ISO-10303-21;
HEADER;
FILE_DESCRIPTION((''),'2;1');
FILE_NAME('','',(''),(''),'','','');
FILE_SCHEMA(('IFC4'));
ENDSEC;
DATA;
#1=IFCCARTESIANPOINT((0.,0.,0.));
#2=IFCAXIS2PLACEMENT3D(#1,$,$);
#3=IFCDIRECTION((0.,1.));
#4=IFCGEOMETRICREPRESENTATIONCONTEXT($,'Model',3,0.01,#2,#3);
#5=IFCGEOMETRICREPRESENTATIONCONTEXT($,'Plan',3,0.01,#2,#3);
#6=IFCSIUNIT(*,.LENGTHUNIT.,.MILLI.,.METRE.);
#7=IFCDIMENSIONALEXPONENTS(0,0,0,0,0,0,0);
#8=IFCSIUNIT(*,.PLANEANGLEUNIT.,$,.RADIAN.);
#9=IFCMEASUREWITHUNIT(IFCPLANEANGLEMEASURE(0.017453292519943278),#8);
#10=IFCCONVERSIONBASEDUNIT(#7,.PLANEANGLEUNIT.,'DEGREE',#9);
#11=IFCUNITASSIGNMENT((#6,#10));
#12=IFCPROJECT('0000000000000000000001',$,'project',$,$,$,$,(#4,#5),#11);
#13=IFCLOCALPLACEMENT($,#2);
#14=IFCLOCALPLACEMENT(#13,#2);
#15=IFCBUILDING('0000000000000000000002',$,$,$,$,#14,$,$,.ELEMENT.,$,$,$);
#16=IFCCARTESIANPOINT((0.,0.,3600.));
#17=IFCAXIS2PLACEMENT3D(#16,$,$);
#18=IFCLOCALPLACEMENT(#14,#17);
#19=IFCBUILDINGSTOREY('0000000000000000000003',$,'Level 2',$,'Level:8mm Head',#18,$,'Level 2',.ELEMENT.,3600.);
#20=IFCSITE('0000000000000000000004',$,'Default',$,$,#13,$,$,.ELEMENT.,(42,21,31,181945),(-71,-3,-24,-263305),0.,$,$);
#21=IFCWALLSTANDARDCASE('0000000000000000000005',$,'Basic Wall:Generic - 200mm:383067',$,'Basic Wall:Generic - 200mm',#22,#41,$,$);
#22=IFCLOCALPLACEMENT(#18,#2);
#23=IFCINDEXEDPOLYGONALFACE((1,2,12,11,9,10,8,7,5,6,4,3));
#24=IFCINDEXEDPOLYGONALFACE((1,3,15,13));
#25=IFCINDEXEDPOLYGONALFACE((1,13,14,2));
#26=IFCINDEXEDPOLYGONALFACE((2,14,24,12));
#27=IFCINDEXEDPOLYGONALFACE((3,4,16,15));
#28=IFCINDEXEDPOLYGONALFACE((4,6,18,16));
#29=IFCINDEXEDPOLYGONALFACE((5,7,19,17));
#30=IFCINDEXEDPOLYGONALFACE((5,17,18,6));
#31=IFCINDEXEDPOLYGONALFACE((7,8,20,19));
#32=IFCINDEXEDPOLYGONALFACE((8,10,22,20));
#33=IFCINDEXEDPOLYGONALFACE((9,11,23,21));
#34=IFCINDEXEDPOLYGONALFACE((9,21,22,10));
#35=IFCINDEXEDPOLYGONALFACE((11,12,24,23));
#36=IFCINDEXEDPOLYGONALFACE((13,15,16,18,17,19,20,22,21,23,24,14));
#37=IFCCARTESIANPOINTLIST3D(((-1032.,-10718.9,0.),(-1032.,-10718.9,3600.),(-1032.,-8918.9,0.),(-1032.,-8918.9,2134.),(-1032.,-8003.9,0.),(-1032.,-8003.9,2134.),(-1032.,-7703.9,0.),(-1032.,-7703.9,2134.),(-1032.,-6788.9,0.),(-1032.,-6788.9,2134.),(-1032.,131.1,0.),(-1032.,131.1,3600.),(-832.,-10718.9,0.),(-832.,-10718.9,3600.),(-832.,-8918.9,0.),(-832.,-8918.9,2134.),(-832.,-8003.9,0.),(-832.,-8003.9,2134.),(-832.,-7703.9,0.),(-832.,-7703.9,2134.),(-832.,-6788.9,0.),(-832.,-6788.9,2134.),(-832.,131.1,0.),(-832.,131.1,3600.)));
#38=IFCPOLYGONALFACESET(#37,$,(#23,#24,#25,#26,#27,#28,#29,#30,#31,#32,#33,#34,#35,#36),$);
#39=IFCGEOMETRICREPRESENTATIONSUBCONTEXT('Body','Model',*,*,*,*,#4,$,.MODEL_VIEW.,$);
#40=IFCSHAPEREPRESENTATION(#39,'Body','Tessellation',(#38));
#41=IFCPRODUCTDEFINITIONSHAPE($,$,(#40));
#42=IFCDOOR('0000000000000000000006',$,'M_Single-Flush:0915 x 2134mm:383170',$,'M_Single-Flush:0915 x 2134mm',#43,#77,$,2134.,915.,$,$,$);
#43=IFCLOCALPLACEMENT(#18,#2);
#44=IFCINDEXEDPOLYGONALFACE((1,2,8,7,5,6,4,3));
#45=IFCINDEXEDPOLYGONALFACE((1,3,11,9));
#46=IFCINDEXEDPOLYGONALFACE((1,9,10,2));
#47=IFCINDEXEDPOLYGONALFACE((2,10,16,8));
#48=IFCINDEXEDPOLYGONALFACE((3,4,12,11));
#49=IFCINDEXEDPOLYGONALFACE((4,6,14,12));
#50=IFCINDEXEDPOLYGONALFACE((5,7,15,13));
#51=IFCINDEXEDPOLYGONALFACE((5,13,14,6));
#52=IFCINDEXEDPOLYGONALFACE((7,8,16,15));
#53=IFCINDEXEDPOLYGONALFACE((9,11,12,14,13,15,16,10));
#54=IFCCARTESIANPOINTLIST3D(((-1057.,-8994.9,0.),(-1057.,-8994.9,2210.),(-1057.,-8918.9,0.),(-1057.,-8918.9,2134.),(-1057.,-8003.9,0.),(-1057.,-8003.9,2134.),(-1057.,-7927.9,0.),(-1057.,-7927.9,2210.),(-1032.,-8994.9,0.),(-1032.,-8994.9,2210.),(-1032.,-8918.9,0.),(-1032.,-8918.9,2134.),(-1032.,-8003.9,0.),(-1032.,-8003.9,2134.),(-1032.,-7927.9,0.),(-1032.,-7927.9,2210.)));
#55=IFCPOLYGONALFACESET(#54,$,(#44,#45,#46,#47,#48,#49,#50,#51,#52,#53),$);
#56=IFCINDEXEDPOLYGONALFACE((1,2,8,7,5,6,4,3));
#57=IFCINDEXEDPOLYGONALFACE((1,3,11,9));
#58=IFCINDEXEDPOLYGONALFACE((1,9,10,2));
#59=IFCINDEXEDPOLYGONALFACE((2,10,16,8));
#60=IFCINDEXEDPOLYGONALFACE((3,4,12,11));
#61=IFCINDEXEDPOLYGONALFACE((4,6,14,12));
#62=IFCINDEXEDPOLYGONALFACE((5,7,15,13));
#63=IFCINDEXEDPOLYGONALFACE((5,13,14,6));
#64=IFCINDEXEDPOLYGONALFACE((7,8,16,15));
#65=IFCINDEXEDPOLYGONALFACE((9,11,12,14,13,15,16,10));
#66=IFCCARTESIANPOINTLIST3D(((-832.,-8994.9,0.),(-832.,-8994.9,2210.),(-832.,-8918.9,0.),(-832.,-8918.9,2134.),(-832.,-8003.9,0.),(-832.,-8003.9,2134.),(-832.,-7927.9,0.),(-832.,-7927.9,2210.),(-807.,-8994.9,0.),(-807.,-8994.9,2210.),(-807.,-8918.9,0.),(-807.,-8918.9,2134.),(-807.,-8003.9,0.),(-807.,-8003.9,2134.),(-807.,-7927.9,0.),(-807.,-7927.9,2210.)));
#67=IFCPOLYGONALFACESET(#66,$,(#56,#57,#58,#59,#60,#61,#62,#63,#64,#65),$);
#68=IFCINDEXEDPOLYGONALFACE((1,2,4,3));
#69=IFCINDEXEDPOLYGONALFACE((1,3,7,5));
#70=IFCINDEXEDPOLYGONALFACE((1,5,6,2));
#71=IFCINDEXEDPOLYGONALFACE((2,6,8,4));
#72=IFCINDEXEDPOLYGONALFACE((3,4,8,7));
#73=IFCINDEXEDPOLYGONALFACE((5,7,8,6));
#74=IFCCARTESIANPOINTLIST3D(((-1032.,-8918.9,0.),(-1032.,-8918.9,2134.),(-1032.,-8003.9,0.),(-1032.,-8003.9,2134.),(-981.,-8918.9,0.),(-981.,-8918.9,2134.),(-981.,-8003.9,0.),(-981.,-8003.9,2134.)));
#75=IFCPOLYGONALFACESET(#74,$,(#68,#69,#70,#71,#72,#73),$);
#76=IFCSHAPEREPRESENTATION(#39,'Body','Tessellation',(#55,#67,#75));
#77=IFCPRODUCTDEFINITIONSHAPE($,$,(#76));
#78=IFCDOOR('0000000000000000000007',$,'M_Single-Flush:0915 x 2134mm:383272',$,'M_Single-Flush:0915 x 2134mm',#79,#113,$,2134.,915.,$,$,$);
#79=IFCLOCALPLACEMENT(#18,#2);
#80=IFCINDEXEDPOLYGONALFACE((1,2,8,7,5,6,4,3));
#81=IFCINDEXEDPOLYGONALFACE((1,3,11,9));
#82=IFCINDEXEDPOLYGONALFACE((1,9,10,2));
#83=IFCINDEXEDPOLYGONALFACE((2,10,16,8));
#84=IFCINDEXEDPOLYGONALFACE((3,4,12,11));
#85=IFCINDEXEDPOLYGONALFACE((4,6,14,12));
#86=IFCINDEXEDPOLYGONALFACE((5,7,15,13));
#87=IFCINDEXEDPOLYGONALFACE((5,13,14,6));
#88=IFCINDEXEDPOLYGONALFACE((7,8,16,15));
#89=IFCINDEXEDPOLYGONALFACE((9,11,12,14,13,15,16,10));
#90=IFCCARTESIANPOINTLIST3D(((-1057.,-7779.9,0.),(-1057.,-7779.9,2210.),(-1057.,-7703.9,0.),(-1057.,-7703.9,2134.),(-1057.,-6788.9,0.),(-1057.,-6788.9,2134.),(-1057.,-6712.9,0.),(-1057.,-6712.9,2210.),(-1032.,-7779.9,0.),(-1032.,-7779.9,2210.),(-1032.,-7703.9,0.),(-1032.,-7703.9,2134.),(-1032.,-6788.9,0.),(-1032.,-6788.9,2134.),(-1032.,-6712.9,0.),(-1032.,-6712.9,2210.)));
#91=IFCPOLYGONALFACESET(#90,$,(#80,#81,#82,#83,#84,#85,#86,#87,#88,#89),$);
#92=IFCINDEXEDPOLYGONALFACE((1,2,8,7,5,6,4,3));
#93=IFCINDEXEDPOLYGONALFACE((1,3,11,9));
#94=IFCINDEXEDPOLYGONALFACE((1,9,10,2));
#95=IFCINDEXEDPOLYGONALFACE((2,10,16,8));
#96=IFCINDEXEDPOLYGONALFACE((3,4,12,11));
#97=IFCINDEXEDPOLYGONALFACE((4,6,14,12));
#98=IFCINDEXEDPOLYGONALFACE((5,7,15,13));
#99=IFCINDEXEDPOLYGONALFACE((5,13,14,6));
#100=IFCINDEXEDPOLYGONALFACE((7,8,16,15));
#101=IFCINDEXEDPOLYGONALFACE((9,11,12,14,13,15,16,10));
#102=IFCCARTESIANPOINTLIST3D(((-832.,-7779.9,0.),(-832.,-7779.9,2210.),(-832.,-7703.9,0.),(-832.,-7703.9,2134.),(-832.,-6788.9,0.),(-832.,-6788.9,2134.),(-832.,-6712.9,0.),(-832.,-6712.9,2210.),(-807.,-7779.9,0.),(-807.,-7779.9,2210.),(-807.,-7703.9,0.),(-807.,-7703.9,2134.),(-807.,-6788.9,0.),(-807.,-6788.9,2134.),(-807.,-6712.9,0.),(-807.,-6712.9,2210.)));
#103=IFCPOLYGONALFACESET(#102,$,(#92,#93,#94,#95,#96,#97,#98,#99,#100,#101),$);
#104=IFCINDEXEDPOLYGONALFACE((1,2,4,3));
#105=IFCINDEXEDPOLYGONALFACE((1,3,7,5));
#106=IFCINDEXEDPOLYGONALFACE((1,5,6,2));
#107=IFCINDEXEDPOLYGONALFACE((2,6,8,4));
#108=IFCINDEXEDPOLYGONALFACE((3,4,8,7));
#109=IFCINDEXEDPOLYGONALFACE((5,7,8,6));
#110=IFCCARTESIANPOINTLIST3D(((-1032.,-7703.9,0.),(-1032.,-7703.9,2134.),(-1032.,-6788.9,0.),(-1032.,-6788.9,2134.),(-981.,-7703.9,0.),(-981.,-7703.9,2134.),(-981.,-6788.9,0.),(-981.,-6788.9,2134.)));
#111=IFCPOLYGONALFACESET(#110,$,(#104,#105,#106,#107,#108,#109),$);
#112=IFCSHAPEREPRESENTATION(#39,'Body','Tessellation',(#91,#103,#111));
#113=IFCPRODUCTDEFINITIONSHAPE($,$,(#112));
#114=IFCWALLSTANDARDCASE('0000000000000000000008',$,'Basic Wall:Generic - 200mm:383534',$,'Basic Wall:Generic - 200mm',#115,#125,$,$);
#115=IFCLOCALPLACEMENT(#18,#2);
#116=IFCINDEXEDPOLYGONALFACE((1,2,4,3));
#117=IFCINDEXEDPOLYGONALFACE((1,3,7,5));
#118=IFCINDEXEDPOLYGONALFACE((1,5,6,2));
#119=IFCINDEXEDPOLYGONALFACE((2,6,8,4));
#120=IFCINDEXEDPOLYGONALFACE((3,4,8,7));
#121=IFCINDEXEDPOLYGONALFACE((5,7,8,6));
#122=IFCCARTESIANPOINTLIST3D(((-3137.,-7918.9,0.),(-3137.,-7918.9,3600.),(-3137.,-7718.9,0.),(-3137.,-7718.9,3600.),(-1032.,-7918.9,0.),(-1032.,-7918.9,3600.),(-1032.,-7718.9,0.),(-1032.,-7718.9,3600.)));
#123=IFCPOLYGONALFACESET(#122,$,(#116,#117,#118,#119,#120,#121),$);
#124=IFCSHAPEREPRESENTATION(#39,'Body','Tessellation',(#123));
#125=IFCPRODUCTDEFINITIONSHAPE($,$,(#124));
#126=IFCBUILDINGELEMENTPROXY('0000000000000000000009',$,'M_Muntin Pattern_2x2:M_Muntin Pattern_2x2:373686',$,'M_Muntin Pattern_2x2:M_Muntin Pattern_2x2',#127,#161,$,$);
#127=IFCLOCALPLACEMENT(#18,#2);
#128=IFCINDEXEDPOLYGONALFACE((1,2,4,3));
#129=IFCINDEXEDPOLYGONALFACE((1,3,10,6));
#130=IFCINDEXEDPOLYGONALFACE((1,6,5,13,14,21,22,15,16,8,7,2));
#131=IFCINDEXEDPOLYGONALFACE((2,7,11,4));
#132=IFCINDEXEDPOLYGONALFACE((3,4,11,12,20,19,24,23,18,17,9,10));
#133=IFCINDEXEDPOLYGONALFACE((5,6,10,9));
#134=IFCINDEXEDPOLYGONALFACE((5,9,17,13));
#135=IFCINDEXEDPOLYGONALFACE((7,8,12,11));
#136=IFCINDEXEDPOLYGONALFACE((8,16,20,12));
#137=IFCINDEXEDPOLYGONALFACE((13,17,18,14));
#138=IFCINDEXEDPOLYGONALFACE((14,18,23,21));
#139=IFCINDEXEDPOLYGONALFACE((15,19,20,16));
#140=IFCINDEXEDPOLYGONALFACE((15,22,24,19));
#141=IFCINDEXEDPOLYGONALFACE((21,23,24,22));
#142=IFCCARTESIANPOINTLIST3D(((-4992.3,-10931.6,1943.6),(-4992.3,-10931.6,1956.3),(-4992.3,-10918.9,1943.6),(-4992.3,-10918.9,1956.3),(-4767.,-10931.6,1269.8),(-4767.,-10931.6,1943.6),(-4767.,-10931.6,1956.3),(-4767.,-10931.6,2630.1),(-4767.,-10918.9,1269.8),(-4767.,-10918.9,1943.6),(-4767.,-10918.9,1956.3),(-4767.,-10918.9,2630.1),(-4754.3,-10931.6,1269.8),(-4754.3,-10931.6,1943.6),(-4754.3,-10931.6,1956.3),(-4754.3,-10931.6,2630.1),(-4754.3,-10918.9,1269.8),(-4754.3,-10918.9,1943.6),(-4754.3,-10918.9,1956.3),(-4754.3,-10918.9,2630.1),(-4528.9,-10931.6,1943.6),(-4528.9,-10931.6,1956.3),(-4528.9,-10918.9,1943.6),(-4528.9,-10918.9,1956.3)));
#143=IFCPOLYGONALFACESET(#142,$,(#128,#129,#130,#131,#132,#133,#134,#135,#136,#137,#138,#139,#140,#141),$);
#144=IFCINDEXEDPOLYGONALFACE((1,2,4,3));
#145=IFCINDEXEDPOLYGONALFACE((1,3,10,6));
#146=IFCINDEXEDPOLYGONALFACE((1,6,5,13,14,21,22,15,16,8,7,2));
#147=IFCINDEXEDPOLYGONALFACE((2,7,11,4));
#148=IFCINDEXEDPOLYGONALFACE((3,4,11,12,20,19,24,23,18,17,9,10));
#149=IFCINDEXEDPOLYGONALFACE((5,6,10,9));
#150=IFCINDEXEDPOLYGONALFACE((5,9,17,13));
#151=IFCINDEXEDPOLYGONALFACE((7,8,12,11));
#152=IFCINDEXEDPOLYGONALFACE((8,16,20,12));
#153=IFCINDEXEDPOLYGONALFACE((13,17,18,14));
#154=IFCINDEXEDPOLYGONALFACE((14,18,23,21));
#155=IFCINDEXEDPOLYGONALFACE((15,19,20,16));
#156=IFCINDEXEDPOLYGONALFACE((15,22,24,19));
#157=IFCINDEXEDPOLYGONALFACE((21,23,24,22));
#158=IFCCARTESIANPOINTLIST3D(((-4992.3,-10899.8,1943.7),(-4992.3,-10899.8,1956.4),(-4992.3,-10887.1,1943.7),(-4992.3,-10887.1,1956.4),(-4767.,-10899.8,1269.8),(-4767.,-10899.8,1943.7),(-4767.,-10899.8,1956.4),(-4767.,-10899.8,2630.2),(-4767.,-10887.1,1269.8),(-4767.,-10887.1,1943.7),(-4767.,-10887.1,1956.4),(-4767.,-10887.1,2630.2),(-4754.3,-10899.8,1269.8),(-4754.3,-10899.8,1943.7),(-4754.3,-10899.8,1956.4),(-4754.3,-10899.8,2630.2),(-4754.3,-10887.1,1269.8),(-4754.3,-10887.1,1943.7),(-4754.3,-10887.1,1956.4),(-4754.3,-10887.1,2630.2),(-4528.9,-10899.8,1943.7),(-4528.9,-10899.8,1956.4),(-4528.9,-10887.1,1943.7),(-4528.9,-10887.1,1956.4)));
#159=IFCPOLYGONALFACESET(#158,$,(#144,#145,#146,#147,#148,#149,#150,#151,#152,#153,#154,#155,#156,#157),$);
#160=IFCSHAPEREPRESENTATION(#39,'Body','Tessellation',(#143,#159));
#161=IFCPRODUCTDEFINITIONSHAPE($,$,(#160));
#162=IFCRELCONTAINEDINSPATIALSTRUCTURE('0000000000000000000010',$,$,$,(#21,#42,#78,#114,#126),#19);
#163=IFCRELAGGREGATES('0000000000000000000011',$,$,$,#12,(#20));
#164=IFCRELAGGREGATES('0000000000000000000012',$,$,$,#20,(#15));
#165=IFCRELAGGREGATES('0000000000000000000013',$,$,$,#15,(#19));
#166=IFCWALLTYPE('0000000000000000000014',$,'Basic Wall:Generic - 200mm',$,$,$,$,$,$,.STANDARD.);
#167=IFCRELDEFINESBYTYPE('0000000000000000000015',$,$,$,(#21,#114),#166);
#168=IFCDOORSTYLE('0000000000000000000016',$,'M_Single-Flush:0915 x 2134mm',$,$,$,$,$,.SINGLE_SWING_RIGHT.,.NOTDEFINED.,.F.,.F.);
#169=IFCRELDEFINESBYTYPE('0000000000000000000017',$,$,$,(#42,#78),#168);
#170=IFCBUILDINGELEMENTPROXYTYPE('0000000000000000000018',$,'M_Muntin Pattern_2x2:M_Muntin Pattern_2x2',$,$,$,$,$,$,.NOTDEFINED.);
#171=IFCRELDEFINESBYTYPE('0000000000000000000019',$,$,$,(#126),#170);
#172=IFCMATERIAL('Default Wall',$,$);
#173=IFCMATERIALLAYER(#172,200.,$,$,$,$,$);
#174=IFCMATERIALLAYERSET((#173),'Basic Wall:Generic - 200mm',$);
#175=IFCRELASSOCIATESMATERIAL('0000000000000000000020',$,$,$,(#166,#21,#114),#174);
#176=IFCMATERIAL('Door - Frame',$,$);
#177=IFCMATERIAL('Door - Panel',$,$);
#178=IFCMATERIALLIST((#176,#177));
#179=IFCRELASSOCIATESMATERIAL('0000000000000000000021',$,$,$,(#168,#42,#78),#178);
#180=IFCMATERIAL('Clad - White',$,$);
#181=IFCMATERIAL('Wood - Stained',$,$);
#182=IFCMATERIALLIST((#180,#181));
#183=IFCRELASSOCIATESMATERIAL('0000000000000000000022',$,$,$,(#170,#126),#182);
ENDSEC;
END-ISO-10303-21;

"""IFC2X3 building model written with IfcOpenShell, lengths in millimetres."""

from ifc_helpers import new_model, entity, si_unit, converted_unit, direction, frame, frame_2d, origin, place, context, subcontext, project, spatial, polyline, rectangle, outline, extrude, source, transform, mapped, material, material_list, layer, layer_set, layer_usage, type_object, type_shapes, element, fill, save


model = new_model("IFC2X3")

# Units and contexts
model_context = context("Model", 3, precision=0.01, world=origin(), true_north=direction((0.0, 1.0)))
plan_context = context("Plan", 3, precision=0.01, world=origin(), true_north=direction((0.0, 1.0)))
body_context = subcontext(model_context, "Body", "Model", "MODEL_VIEW")
ifc_project = project(units=[si_unit("LENGTHUNIT", "METRE", prefix="MILLI"), converted_unit("PLANEANGLEUNIT", "DEGREE", entity("IfcPlaneAngleMeasure", 0.017453292519943278), si_unit("PLANEANGLEUNIT", "RADIAN"), dimensions=[0, 0, 0, 0, 0, 0, 0])], contexts=[model_context, plan_context])

# Site, building, storey
site_placement = place(None, origin())
site = spatial("IfcSite", under=ifc_project, at=site_placement, Name="Default", CompositionType="ELEMENT", RefLatitude=(42, 21, 31, 181945), RefLongitude=(-71, -3, -24, -263305), RefElevation=0.0)
building_placement = place(site_placement, origin())
building = spatial("IfcBuilding", under=site, at=building_placement, CompositionType="ELEMENT")
storey_placement = place(building_placement, frame((0.0, 0.0, 3600.0)))
storey = spatial("IfcBuildingStorey", under=building, at=storey_placement, Name="Level 2", ObjectType="Level:8mm Head", LongName="Level 2", CompositionType="ELEMENT", Elevation=3600.0)

# Shared definitions
ifc_material_1 = material(Name="Default Wall")
ifc_layer = layer(ifc_material_1, 200.0)
ifc_layer_set = layer_set([ifc_layer], Name="Basic Wall:Generic - 200mm")
wall_type = type_object("IfcWallType", Name="Basic Wall:Generic - 200mm", PredefinedType="STANDARD", material=ifc_layer_set)

# Wall, openings, doors
ifc_layer_usage_1 = layer_usage(ifc_layer_set, "AXIS2", "NEGATIVE", 100.0)
wall_1_placement = place(storey_placement, frame((-932.0, -10718.9, 0.0), z_axis=(0.0, 0.0, 1.0), x_axis=(0.0, 1.0, 0.0)))
wall_1 = element("IfcWallStandardCase", 1, at=wall_1_placement, inside=storey, type_object=wall_type, material=ifc_layer_usage_1, Name="Basic Wall:Generic - 200mm:383067", ObjectType="Basic Wall:Generic - 200mm", context=body_context, shape_type="SweptSolid", body=[
    extrude(rectangle(XDim=10850.0, YDim=200.0, at=frame_2d((5425.0, 0.0), x_axis=(1.0, 0.0))), origin(), (0.0, 0.0, 1.0), 3600.0),
])
opening_1_placement = place(wall_1_placement, frame((1800.0, -100.0, 0.0)))
opening_1 = element("IfcOpeningElement", 2, at=opening_1_placement, cuts=wall_1, ObjectType="Opening", context=body_context, shape_type="SweptSolid", body=[
    extrude(rectangle(XDim=915.0, YDim=2134.0, at=frame_2d((1067.0, 457.5), x_axis=(0.0, 1.0))), frame((0.0, 0.0, 0.0), z_axis=(0.0, 1.0, 0.0), x_axis=(0.0, 0.0, 1.0)), (0.0, 0.0, 1.0), 200.0),
])
opening_2_placement = place(wall_1_placement, frame((3015.0, -100.0, 0.0)))
opening_2 = element("IfcOpeningElement", 3, at=opening_2_placement, cuts=wall_1, ObjectType="Opening", context=body_context, shape_type="SweptSolid", body=[
    extrude(rectangle(XDim=915.0, YDim=2134.0, at=frame_2d((1067.0, 457.5), x_axis=(0.0, 1.0))), frame((0.0, 0.0, 0.0), z_axis=(0.0, 1.0, 0.0), x_axis=(0.0, 0.0, 1.0)), (0.0, 0.0, 1.0), 200.0),
])
ifc_material_2 = material(Name="Door - Frame")
ifc_material_3 = material(Name="Door - Panel")
ifc_material_list_1 = material_list([ifc_material_2, ifc_material_3])
door_style = type_object("IfcDoorStyle", Name="M_Single-Flush:0915 x 2134mm", ConstructionType="NOTDEFINED", OperationType="SINGLE_SWING_RIGHT", ParameterTakesPrecedence=False, Sizeable=False, material=ifc_material_list_1)
shared_shape_1 = source(origin(), body_context, "Body", "SweptSolid", [
    extrude(outline(polyline([(-533.5, -1124.0), (533.5, -1124.0), (533.5, 1086.0), (457.5, 1086.0), (457.5, -1048.0), (-457.5, -1048.0), (-457.5, 1086.0), (-533.5, 1086.0), (-533.5, -1124.0)])), frame((457.5, 200.0, 1086.0), z_axis=(0.0, 1.0, 0.0), x_axis=(1.0, 0.0, 0.0)), (0.0, 0.0, 1.0), 25.0),
    extrude(outline(polyline([(-1124.0, -533.5), (1086.0, -533.5), (1086.0, -457.5), (-1048.0, -457.5), (-1048.0, 457.5), (1086.0, 457.5), (1086.0, 533.5), (-1124.0, 533.5), (-1124.0, -533.5)])), frame((457.5, -25.0, 1086.0), z_axis=(0.0, 1.0, 0.0), x_axis=(0.0, 0.0, -1.0)), (0.0, 0.0, 1.0), 25.0),
    extrude(rectangle(XDim=51.0, YDim=915.0, at=frame_2d((0.0, 0.0), x_axis=(1.0, 0.0))), frame((457.5, 174.5, 0.0), z_axis=(0.0, 0.0, 1.0), x_axis=(0.0, 1.0, 0.0)), (0.0, 0.0, 1.0), 2134.0),
])
type_shapes(door_style, [shared_shape_1])
door_1_placement = place(opening_1_placement, origin())
door_1 = element("IfcDoor", 4, at=door_1_placement, inside=storey, type_object=door_style, material=ifc_material_list_1, Name="M_Single-Flush:0915 x 2134mm:383170", ObjectType="M_Single-Flush:0915 x 2134mm", OverallHeight=2134.0, OverallWidth=915.0, context=body_context, shape_type="MappedRepresentation", body=[
    mapped(shared_shape_1, transform((0.0, 0.0, 0.0), scale=1.0)),
])
fill(opening_1, door_1)
door_2_placement = place(opening_2_placement, origin())
door_2 = element("IfcDoor", 5, at=door_2_placement, inside=storey, type_object=door_style, material=ifc_material_list_1, Name="M_Single-Flush:0915 x 2134mm:383272", ObjectType="M_Single-Flush:0915 x 2134mm", OverallHeight=2134.0, OverallWidth=915.0, context=body_context, shape_type="MappedRepresentation", body=[
    mapped(shared_shape_1, transform((0.0, 0.0, 0.0), scale=1.0)),
])
fill(opening_2, door_2)

# Wall
ifc_layer_usage_2 = layer_usage(ifc_layer_set, "AXIS2", "NEGATIVE", 100.0)
wall_2_placement = place(storey_placement, frame((-3137.0, -7818.9, 0.0)))
element("IfcWallStandardCase", 6, at=wall_2_placement, inside=storey, type_object=wall_type, material=ifc_layer_usage_2, Name="Basic Wall:Generic - 200mm:383534", ObjectType="Basic Wall:Generic - 200mm", context=body_context, shape_type="SweptSolid", body=[
    extrude(rectangle(XDim=2105.0, YDim=200.0, at=frame_2d((1052.5, 0.0), x_axis=(-1.0, 0.0))), origin(), (0.0, 0.0, 1.0), 3600.0),
])

# Building element proxy
ifc_material_4 = material(Name="Clad - White")
ifc_material_5 = material(Name="Wood - Stained")
ifc_material_list_2 = material_list([ifc_material_4, ifc_material_5])
building_element_proxy_type_1 = type_object("IfcBuildingElementProxyType", Name="M_Muntin Pattern_2x2:M_Muntin Pattern_2x2", PredefinedType="NOTDEFINED", material=ifc_material_list_2)
shared_shape_2 = source(origin(), body_context, "Body", "SweptSolid", [
    extrude(outline(polyline([(6.4, -6.4), (680.1, -6.4), (680.1, 6.3), (6.4, 6.3), (6.4, 231.7), (-6.3, 231.7), (-6.3, 6.3), (-680.2, 6.3), (-680.2, -6.4), (-6.3, -6.4), (-6.3, -231.7), (6.4, -231.7), (6.4, -6.4)])), frame((0.0, 9.5, 680.1), z_axis=(0.0, 1.0, 0.0), x_axis=(0.0, 0.0, 1.0)), (0.0, 0.0, 1.0), 12.7),
    extrude(outline(polyline([(6.4, -6.4), (680.2, -6.4), (680.2, 6.3), (6.4, 6.3), (6.4, 231.7), (-6.3, 231.7), (-6.3, 6.3), (-680.2, 6.3), (-680.2, -6.4), (-6.3, -6.4), (-6.3, -231.7), (6.4, -231.7), (6.4, -6.4)])), frame((0.0, -22.2, 680.2), z_axis=(0.0, 1.0, 0.0), x_axis=(0.0, 0.0, 1.0)), (0.0, 0.0, 1.0), 12.7),
])
type_shapes(building_element_proxy_type_1, [shared_shape_2])
for number, where, z_axis, x_axis, name in (
    (7, (-4760.6, -10909.4, 1269.8), (0.0, 0.0, 1.0), (-1.0, 0.0, 0.0), "M_Muntin Pattern_2x2:M_Muntin Pattern_2x2:373686"),
):
    element("IfcBuildingElementProxy", number, at=place(storey_placement, frame(where, z_axis=z_axis, x_axis=x_axis)), inside=storey, type_object=building_element_proxy_type_1, material=ifc_material_list_2, Name=name, ObjectType="M_Muntin Pattern_2x2:M_Muntin Pattern_2x2", context=body_context, shape_type="MappedRepresentation", body=[
        mapped(shared_shape_2, transform((0.0, 0.0, 0.0), scale=1.0)),
    ])

save(model, "model.ifc")
